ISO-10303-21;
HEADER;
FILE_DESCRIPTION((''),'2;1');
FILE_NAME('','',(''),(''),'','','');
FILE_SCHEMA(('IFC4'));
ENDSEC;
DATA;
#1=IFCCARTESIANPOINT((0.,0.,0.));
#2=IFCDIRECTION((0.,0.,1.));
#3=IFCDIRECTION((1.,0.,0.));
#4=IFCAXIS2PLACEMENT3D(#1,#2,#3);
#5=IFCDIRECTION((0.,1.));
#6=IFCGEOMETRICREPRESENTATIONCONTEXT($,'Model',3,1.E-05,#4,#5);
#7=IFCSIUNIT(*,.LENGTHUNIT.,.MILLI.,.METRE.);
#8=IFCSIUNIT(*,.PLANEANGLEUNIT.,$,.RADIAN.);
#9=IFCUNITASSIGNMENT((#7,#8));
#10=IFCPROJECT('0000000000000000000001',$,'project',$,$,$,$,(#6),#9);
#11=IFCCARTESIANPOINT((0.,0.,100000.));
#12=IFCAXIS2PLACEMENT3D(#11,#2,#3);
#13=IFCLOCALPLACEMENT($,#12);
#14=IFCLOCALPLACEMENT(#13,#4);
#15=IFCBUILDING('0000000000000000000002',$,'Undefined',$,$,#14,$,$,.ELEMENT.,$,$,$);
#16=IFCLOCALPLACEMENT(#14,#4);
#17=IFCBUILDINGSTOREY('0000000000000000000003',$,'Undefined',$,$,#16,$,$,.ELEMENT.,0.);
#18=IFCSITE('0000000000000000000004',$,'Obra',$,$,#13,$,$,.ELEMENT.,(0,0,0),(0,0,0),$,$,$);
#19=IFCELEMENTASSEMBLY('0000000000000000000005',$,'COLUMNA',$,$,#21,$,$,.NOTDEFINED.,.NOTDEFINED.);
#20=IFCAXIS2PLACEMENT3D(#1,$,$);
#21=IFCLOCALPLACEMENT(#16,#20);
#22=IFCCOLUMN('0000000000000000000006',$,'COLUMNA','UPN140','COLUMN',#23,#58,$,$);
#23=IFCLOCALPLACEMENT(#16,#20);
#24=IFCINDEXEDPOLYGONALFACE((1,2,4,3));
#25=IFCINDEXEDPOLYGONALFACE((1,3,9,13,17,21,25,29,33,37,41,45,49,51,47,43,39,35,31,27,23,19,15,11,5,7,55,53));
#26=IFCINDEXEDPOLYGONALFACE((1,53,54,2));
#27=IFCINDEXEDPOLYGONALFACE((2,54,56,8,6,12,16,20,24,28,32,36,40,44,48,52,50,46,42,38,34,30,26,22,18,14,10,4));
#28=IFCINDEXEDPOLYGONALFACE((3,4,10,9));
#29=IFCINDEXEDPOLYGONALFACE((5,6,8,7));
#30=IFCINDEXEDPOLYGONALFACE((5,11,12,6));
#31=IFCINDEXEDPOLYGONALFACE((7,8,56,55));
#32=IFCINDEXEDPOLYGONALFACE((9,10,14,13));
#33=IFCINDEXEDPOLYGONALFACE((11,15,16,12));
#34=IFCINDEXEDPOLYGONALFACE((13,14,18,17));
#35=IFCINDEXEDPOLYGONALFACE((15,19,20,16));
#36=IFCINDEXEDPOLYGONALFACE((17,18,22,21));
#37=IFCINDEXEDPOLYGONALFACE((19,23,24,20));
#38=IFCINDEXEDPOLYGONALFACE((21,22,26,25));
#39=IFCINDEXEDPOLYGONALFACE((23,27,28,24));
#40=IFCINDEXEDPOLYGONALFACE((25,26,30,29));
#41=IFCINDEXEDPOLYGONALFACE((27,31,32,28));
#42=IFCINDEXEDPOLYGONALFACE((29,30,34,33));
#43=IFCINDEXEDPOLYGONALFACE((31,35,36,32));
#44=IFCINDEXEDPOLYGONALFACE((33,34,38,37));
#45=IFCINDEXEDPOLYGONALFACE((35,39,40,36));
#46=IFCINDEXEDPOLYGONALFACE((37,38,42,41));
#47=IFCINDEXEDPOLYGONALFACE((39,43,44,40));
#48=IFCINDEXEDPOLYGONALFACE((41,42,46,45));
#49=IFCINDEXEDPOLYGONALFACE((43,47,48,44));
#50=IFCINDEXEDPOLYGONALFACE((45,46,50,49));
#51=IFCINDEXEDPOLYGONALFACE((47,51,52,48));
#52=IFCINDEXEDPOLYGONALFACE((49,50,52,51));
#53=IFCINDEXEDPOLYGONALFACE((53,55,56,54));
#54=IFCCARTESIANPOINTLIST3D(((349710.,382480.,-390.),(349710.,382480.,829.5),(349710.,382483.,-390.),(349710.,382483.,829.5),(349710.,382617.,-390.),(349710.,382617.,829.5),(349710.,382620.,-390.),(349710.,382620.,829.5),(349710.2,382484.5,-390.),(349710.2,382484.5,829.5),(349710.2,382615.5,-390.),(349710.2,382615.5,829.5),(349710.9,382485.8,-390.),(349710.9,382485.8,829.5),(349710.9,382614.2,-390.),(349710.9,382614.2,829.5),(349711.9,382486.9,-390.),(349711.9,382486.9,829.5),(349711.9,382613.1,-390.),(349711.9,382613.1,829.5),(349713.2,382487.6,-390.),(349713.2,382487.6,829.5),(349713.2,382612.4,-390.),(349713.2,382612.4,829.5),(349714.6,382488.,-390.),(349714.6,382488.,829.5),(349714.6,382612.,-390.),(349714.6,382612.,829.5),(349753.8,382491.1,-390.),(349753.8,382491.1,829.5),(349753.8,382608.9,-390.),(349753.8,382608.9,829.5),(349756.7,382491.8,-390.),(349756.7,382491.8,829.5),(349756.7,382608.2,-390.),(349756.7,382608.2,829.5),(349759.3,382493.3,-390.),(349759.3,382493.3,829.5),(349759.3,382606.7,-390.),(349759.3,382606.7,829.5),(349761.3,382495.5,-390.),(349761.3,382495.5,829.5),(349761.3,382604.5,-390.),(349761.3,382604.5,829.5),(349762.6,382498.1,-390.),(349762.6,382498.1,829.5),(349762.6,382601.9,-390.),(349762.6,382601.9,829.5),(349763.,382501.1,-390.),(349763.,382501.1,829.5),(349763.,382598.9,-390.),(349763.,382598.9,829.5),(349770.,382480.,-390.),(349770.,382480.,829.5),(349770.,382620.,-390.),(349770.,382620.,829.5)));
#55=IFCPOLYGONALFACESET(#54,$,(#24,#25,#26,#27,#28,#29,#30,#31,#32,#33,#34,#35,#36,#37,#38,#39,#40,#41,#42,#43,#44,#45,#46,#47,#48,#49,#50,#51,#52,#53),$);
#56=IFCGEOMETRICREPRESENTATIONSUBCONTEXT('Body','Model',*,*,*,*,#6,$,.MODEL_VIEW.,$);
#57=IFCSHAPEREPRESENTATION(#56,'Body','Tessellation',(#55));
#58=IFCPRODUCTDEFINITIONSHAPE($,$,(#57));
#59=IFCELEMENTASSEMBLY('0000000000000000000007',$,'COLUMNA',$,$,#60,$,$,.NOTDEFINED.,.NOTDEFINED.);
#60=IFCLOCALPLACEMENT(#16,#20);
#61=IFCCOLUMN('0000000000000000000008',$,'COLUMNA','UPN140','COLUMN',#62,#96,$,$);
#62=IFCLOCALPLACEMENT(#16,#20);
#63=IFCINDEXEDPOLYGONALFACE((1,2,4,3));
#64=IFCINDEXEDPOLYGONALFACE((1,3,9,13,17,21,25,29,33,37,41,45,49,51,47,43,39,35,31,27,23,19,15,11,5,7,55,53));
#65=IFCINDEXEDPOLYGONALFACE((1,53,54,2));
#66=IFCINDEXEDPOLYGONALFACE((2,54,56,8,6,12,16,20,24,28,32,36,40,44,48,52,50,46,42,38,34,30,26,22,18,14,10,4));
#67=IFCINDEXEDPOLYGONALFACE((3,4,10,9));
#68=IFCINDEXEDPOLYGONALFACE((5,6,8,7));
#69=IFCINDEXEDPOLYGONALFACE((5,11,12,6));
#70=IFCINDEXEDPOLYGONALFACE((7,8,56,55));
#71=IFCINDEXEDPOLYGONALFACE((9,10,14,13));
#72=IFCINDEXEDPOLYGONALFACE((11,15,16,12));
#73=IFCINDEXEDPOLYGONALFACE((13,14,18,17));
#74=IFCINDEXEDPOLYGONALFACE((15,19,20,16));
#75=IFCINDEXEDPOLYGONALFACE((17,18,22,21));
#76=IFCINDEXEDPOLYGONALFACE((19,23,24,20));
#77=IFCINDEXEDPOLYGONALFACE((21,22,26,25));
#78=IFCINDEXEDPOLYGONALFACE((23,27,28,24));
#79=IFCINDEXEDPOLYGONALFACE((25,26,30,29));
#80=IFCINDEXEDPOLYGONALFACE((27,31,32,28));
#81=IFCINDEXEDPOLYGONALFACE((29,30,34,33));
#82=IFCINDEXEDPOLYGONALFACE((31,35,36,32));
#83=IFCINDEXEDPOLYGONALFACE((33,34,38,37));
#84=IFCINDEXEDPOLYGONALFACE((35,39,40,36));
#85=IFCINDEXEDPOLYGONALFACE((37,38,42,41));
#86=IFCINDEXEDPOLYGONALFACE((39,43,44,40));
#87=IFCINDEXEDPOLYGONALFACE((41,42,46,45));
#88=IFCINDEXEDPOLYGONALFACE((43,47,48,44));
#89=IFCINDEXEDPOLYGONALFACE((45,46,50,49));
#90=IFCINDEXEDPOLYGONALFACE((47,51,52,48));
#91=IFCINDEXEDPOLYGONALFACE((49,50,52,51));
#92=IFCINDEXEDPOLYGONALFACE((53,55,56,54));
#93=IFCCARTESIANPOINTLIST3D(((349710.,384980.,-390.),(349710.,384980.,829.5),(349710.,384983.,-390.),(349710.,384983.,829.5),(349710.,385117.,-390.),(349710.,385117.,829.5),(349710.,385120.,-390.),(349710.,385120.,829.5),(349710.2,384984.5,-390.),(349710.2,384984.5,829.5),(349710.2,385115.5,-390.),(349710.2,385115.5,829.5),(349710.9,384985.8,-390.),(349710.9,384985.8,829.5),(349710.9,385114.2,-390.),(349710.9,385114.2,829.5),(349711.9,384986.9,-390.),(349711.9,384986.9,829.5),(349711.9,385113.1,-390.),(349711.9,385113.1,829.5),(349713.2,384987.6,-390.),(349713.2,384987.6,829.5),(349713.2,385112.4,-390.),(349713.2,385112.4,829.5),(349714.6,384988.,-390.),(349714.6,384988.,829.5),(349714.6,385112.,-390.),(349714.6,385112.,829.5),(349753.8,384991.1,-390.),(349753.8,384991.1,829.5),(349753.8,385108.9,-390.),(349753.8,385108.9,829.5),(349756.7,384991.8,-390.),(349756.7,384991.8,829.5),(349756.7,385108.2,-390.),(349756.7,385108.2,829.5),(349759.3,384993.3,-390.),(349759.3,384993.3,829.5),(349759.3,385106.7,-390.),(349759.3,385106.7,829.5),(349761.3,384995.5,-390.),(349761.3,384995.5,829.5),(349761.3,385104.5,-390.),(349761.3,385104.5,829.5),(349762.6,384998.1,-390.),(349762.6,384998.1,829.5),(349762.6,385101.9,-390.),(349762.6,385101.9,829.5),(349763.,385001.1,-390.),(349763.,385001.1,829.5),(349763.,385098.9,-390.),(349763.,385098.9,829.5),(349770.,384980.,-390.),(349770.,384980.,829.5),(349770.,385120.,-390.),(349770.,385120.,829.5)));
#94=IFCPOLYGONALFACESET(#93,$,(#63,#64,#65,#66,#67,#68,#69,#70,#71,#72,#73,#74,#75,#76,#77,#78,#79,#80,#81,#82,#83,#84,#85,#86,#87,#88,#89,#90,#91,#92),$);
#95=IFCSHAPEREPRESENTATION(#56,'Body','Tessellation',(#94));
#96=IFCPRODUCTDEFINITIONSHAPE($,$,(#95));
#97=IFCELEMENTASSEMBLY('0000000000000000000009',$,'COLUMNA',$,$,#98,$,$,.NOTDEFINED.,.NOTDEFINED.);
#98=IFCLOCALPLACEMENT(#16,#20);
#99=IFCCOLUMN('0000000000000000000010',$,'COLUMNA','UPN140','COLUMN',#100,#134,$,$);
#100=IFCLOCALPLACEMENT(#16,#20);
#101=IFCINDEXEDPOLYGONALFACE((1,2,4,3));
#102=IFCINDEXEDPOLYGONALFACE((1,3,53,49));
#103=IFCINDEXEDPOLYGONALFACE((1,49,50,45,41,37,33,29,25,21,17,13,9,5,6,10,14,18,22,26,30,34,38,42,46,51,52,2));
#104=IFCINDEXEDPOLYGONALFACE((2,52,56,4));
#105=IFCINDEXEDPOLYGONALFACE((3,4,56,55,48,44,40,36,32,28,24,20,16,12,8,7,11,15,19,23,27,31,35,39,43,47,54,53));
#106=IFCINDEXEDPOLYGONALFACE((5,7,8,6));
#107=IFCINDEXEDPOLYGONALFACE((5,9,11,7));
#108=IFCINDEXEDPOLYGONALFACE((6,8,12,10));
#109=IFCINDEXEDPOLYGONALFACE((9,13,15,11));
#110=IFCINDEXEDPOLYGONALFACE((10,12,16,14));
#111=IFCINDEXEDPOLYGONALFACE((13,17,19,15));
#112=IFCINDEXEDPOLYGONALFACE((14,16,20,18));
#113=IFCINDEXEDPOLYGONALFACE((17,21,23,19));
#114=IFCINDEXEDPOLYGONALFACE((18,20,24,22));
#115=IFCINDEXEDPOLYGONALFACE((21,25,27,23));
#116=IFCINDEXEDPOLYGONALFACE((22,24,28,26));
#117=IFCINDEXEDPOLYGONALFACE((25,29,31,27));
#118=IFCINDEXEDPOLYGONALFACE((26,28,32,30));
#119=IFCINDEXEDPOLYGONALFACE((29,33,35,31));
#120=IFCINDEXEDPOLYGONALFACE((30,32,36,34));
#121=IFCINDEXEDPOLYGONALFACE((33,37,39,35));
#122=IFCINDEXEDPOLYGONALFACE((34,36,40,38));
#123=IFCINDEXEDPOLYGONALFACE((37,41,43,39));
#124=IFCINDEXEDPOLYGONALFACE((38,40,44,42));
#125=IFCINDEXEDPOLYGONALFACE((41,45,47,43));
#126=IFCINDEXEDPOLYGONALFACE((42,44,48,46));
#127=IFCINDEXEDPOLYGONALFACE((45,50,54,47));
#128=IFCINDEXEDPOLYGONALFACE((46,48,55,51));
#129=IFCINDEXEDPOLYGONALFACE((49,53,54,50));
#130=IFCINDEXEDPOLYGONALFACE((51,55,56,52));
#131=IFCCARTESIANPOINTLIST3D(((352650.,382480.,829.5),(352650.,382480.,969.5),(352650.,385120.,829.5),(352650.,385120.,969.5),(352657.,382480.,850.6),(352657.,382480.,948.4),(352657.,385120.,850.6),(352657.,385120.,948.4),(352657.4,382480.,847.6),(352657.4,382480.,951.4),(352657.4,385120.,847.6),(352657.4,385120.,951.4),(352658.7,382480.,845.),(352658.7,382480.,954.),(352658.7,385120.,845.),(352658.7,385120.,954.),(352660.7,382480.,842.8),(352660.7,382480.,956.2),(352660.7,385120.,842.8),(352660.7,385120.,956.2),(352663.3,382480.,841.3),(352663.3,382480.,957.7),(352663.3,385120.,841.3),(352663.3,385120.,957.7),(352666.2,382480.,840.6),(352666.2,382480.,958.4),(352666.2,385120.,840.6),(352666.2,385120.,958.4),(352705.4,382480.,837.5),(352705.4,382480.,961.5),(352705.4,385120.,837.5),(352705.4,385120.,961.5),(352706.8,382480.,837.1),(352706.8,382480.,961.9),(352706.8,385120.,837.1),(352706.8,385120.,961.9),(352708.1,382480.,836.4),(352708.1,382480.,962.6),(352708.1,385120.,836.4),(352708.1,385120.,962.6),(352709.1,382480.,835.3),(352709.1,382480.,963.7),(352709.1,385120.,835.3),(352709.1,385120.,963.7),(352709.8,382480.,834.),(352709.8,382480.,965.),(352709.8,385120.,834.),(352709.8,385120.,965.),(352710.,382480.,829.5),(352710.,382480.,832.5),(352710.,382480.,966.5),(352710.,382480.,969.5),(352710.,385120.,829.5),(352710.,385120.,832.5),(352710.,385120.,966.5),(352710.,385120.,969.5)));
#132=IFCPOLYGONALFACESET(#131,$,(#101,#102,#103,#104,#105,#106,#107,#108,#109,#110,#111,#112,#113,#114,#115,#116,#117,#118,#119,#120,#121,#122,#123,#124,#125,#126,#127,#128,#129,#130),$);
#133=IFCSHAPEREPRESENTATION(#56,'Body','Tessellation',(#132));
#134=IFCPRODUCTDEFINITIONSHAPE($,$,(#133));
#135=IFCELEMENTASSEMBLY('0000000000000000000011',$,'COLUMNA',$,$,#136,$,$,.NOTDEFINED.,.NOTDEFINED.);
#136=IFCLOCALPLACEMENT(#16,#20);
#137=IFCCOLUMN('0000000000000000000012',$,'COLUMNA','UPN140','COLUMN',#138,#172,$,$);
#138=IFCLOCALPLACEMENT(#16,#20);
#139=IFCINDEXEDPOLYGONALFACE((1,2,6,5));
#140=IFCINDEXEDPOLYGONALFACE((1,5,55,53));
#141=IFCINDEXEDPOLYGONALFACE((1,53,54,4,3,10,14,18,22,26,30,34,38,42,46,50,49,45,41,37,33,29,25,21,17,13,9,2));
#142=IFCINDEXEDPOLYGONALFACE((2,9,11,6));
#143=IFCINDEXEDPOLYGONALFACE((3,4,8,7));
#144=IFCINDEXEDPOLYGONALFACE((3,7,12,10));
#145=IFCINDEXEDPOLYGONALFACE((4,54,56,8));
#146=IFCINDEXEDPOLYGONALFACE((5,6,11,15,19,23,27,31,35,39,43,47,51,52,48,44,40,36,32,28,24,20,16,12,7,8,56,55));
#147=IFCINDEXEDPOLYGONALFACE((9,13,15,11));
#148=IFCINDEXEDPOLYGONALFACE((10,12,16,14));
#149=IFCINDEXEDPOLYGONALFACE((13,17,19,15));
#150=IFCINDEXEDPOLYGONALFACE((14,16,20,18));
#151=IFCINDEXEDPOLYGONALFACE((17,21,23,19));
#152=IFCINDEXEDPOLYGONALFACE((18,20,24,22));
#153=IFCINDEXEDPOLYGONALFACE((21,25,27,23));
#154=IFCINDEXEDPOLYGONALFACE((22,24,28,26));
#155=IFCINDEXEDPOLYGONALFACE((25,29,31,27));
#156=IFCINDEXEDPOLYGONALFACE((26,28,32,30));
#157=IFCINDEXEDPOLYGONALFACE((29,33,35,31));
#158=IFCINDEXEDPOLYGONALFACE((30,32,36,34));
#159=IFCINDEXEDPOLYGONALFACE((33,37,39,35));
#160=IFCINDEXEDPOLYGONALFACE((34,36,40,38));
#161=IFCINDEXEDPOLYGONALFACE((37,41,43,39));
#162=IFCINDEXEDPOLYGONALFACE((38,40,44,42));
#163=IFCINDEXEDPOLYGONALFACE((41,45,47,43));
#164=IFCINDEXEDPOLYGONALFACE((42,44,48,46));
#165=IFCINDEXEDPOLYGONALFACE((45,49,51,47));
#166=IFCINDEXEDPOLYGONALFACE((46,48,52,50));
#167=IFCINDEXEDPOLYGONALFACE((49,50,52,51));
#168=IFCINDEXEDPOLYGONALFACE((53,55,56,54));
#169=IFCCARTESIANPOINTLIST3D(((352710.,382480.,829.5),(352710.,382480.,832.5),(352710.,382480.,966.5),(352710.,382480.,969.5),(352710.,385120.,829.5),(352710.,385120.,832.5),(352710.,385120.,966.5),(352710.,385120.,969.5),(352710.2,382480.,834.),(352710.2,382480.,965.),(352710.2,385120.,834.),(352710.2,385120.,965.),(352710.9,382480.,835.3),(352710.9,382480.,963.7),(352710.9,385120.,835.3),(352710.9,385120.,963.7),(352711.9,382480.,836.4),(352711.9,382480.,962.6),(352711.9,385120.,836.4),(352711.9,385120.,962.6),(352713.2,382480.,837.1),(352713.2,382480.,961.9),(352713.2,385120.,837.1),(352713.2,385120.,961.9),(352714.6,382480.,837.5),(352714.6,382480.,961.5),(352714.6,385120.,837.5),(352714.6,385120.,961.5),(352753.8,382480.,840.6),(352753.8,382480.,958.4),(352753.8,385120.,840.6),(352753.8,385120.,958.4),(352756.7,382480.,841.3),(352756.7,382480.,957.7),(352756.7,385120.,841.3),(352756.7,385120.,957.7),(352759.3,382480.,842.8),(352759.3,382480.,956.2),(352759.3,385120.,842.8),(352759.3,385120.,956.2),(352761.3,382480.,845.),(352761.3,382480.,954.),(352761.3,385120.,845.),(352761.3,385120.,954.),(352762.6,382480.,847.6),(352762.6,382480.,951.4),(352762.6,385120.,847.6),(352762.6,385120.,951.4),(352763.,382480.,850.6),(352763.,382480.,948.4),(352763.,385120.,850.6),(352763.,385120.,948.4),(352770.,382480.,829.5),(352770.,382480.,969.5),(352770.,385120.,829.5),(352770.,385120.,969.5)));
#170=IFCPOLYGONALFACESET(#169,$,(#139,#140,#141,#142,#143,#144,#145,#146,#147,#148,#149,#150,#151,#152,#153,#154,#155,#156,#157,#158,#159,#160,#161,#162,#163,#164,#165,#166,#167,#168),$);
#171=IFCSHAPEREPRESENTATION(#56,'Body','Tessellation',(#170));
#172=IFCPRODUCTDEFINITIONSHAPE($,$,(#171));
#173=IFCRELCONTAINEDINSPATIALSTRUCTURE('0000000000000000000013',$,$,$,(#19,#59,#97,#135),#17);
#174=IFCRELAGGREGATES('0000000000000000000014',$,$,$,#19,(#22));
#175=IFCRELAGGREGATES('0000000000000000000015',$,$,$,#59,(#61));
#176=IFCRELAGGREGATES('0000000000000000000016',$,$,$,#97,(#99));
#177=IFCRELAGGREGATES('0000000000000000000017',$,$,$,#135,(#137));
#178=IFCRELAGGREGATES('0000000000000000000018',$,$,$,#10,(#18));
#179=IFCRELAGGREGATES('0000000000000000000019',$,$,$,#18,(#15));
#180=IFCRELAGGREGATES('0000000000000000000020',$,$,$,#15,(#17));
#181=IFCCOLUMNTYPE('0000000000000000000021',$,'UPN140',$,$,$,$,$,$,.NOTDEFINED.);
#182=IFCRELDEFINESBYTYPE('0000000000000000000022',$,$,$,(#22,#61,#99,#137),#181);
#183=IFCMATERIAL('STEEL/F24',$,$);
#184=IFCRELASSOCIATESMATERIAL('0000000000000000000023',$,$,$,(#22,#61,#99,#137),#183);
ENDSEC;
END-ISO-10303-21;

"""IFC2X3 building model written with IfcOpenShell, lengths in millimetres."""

from ifc_helpers import new_model, si_unit, direction, frame, origin_with_axes, origin_2d_with_axis, place, context, subcontext, project, spatial, u_section, extrude, material, type_object, element, aggregate, save


model = new_model("IFC2X3")

# Units and contexts
model_context = context("Model", 3, precision=1e-05, world=origin_with_axes(), true_north=direction((0.0, 1.0)))
body_context = subcontext(model_context, "Body", "Model", "MODEL_VIEW")
ifc_project = project(units=[si_unit("LENGTHUNIT", "METRE", prefix="MILLI"), si_unit("PLANEANGLEUNIT", "RADIAN")], contexts=[model_context])

# Site, building, storey
site_placement = place(None, frame((0.0, 0.0, 100000.0), z_axis=(0.0, 0.0, 1.0), x_axis=(1.0, 0.0, 0.0)))
site = spatial("IfcSite", under=ifc_project, at=site_placement, Name="Obra", CompositionType="ELEMENT", RefLatitude=(0, 0, 0), RefLongitude=(0, 0, 0))
building_placement = place(site_placement, origin_with_axes())
building = spatial("IfcBuilding", under=site, at=building_placement, Name="Undefined", CompositionType="ELEMENT")
storey_placement = place(building_placement, origin_with_axes())
storey = spatial("IfcBuildingStorey", under=building, at=storey_placement, Name="Undefined", CompositionType="ELEMENT", Elevation=0.0)

# Element assemblies, columns
assembly_1_placement = place(storey_placement, origin_with_axes())
assembly_1 = element("IfcElementAssembly", 1, at=assembly_1_placement, inside=storey, Name="COLUMNA", AssemblyPlace="NOTDEFINED", PredefinedType="NOTDEFINED")
ifc_material_1 = material(Name="STEEL/F24")
column_type_1 = type_object("IfcColumnType", Name="UPN140", PredefinedType="NOTDEFINED")
column_1_placement = place(assembly_1_placement, frame((349740.0, 382550.0, -390.0), z_axis=(0.0, 0.0, 1.0), x_axis=(0.0, 1.0, 0.0)))
column_1 = element("IfcColumn", 2, at=column_1_placement, type_object=column_type_1, material=ifc_material_1, Name="COLUMNA", Description="UPN140", ObjectType="COLUMN", context=body_context, shape_type="SweptSolid", body=[
    extrude(u_section(Depth=140.0, FlangeWidth=60.0, WebThickness=7.0, FlangeThickness=10.0, FilletRadius=10.0, EdgeRadius=5.0, FlangeSlope=0.07983, at=origin_2d_with_axis()), frame((0.0, 0.0, 1219.5), z_axis=(0.0, 0.0, -1.0), x_axis=(0.0, 1.0, 0.0)), (0.0, 0.0, 1.0), 1219.5),
])
aggregate(assembly_1, [column_1])
assembly_2_placement = place(storey_placement, origin_with_axes())
assembly_2 = element("IfcElementAssembly", 3, at=assembly_2_placement, inside=storey, Name="COLUMNA", AssemblyPlace="NOTDEFINED", PredefinedType="NOTDEFINED")
column_2_placement = place(assembly_2_placement, frame((349740.0, 385050.0, -390.0), z_axis=(0.0, 0.0, 1.0), x_axis=(0.0, 1.0, 0.0)))
column_2 = element("IfcColumn", 4, at=column_2_placement, type_object=column_type_1, material=ifc_material_1, Name="COLUMNA", Description="UPN140", ObjectType="COLUMN", context=body_context, shape_type="SweptSolid", body=[
    extrude(u_section(Depth=140.0, FlangeWidth=60.0, WebThickness=7.0, FlangeThickness=10.0, FilletRadius=10.0, EdgeRadius=5.0, FlangeSlope=0.07983, at=origin_2d_with_axis()), frame((0.0, 0.0, 1219.5), z_axis=(0.0, 0.0, -1.0), x_axis=(0.0, 1.0, 0.0)), (0.0, 0.0, 1.0), 1219.5),
])
aggregate(assembly_2, [column_2])
assembly_3_placement = place(storey_placement, origin_with_axes())
assembly_3 = element("IfcElementAssembly", 5, at=assembly_3_placement, inside=storey, Name="COLUMNA", AssemblyPlace="NOTDEFINED", PredefinedType="NOTDEFINED")
column_3_placement = place(assembly_3_placement, frame((352680.0, 385120.0, 899.5), z_axis=(0.0, -1.0, 0.0), x_axis=(0.0, 0.0, -1.0)))
column_3 = element("IfcColumn", 6, at=column_3_placement, type_object=column_type_1, material=ifc_material_1, Name="COLUMNA", Description="UPN140", ObjectType="COLUMN", context=body_context, shape_type="SweptSolid", body=[
    extrude(u_section(Depth=140.0, FlangeWidth=60.0, WebThickness=7.0, FlangeThickness=10.0, FilletRadius=10.0, EdgeRadius=5.0, FlangeSlope=0.07983, at=origin_2d_with_axis()), frame((0.0, 0.0, 2640.0), z_axis=(0.0, 0.0, -1.0), x_axis=(0.0, 1.0, 0.0)), (0.0, 0.0, 1.0), 2640.0),
])
aggregate(assembly_3, [column_3])
assembly_4_placement = place(storey_placement, origin_with_axes())
assembly_4 = element("IfcElementAssembly", 7, at=assembly_4_placement, inside=storey, Name="COLUMNA", AssemblyPlace="NOTDEFINED", PredefinedType="NOTDEFINED")
column_4_placement = place(assembly_4_placement, frame((352740.0, 385120.0, 899.5), z_axis=(0.0, -1.0, 0.0), x_axis=(0.0, 0.0, 1.0)))
column_4 = element("IfcColumn", 8, at=column_4_placement, type_object=column_type_1, material=ifc_material_1, Name="COLUMNA", Description="UPN140", ObjectType="COLUMN", context=body_context, shape_type="SweptSolid", body=[
    extrude(u_section(Depth=140.0, FlangeWidth=60.0, WebThickness=7.0, FlangeThickness=10.0, FilletRadius=10.0, EdgeRadius=5.0, FlangeSlope=0.07983, at=origin_2d_with_axis()), frame((0.0, 0.0, 2640.0), z_axis=(0.0, 0.0, -1.0), x_axis=(0.0, 1.0, 0.0)), (0.0, 0.0, 1.0), 2640.0),
])
aggregate(assembly_4, [column_4])

save(model, "model.ifc")
